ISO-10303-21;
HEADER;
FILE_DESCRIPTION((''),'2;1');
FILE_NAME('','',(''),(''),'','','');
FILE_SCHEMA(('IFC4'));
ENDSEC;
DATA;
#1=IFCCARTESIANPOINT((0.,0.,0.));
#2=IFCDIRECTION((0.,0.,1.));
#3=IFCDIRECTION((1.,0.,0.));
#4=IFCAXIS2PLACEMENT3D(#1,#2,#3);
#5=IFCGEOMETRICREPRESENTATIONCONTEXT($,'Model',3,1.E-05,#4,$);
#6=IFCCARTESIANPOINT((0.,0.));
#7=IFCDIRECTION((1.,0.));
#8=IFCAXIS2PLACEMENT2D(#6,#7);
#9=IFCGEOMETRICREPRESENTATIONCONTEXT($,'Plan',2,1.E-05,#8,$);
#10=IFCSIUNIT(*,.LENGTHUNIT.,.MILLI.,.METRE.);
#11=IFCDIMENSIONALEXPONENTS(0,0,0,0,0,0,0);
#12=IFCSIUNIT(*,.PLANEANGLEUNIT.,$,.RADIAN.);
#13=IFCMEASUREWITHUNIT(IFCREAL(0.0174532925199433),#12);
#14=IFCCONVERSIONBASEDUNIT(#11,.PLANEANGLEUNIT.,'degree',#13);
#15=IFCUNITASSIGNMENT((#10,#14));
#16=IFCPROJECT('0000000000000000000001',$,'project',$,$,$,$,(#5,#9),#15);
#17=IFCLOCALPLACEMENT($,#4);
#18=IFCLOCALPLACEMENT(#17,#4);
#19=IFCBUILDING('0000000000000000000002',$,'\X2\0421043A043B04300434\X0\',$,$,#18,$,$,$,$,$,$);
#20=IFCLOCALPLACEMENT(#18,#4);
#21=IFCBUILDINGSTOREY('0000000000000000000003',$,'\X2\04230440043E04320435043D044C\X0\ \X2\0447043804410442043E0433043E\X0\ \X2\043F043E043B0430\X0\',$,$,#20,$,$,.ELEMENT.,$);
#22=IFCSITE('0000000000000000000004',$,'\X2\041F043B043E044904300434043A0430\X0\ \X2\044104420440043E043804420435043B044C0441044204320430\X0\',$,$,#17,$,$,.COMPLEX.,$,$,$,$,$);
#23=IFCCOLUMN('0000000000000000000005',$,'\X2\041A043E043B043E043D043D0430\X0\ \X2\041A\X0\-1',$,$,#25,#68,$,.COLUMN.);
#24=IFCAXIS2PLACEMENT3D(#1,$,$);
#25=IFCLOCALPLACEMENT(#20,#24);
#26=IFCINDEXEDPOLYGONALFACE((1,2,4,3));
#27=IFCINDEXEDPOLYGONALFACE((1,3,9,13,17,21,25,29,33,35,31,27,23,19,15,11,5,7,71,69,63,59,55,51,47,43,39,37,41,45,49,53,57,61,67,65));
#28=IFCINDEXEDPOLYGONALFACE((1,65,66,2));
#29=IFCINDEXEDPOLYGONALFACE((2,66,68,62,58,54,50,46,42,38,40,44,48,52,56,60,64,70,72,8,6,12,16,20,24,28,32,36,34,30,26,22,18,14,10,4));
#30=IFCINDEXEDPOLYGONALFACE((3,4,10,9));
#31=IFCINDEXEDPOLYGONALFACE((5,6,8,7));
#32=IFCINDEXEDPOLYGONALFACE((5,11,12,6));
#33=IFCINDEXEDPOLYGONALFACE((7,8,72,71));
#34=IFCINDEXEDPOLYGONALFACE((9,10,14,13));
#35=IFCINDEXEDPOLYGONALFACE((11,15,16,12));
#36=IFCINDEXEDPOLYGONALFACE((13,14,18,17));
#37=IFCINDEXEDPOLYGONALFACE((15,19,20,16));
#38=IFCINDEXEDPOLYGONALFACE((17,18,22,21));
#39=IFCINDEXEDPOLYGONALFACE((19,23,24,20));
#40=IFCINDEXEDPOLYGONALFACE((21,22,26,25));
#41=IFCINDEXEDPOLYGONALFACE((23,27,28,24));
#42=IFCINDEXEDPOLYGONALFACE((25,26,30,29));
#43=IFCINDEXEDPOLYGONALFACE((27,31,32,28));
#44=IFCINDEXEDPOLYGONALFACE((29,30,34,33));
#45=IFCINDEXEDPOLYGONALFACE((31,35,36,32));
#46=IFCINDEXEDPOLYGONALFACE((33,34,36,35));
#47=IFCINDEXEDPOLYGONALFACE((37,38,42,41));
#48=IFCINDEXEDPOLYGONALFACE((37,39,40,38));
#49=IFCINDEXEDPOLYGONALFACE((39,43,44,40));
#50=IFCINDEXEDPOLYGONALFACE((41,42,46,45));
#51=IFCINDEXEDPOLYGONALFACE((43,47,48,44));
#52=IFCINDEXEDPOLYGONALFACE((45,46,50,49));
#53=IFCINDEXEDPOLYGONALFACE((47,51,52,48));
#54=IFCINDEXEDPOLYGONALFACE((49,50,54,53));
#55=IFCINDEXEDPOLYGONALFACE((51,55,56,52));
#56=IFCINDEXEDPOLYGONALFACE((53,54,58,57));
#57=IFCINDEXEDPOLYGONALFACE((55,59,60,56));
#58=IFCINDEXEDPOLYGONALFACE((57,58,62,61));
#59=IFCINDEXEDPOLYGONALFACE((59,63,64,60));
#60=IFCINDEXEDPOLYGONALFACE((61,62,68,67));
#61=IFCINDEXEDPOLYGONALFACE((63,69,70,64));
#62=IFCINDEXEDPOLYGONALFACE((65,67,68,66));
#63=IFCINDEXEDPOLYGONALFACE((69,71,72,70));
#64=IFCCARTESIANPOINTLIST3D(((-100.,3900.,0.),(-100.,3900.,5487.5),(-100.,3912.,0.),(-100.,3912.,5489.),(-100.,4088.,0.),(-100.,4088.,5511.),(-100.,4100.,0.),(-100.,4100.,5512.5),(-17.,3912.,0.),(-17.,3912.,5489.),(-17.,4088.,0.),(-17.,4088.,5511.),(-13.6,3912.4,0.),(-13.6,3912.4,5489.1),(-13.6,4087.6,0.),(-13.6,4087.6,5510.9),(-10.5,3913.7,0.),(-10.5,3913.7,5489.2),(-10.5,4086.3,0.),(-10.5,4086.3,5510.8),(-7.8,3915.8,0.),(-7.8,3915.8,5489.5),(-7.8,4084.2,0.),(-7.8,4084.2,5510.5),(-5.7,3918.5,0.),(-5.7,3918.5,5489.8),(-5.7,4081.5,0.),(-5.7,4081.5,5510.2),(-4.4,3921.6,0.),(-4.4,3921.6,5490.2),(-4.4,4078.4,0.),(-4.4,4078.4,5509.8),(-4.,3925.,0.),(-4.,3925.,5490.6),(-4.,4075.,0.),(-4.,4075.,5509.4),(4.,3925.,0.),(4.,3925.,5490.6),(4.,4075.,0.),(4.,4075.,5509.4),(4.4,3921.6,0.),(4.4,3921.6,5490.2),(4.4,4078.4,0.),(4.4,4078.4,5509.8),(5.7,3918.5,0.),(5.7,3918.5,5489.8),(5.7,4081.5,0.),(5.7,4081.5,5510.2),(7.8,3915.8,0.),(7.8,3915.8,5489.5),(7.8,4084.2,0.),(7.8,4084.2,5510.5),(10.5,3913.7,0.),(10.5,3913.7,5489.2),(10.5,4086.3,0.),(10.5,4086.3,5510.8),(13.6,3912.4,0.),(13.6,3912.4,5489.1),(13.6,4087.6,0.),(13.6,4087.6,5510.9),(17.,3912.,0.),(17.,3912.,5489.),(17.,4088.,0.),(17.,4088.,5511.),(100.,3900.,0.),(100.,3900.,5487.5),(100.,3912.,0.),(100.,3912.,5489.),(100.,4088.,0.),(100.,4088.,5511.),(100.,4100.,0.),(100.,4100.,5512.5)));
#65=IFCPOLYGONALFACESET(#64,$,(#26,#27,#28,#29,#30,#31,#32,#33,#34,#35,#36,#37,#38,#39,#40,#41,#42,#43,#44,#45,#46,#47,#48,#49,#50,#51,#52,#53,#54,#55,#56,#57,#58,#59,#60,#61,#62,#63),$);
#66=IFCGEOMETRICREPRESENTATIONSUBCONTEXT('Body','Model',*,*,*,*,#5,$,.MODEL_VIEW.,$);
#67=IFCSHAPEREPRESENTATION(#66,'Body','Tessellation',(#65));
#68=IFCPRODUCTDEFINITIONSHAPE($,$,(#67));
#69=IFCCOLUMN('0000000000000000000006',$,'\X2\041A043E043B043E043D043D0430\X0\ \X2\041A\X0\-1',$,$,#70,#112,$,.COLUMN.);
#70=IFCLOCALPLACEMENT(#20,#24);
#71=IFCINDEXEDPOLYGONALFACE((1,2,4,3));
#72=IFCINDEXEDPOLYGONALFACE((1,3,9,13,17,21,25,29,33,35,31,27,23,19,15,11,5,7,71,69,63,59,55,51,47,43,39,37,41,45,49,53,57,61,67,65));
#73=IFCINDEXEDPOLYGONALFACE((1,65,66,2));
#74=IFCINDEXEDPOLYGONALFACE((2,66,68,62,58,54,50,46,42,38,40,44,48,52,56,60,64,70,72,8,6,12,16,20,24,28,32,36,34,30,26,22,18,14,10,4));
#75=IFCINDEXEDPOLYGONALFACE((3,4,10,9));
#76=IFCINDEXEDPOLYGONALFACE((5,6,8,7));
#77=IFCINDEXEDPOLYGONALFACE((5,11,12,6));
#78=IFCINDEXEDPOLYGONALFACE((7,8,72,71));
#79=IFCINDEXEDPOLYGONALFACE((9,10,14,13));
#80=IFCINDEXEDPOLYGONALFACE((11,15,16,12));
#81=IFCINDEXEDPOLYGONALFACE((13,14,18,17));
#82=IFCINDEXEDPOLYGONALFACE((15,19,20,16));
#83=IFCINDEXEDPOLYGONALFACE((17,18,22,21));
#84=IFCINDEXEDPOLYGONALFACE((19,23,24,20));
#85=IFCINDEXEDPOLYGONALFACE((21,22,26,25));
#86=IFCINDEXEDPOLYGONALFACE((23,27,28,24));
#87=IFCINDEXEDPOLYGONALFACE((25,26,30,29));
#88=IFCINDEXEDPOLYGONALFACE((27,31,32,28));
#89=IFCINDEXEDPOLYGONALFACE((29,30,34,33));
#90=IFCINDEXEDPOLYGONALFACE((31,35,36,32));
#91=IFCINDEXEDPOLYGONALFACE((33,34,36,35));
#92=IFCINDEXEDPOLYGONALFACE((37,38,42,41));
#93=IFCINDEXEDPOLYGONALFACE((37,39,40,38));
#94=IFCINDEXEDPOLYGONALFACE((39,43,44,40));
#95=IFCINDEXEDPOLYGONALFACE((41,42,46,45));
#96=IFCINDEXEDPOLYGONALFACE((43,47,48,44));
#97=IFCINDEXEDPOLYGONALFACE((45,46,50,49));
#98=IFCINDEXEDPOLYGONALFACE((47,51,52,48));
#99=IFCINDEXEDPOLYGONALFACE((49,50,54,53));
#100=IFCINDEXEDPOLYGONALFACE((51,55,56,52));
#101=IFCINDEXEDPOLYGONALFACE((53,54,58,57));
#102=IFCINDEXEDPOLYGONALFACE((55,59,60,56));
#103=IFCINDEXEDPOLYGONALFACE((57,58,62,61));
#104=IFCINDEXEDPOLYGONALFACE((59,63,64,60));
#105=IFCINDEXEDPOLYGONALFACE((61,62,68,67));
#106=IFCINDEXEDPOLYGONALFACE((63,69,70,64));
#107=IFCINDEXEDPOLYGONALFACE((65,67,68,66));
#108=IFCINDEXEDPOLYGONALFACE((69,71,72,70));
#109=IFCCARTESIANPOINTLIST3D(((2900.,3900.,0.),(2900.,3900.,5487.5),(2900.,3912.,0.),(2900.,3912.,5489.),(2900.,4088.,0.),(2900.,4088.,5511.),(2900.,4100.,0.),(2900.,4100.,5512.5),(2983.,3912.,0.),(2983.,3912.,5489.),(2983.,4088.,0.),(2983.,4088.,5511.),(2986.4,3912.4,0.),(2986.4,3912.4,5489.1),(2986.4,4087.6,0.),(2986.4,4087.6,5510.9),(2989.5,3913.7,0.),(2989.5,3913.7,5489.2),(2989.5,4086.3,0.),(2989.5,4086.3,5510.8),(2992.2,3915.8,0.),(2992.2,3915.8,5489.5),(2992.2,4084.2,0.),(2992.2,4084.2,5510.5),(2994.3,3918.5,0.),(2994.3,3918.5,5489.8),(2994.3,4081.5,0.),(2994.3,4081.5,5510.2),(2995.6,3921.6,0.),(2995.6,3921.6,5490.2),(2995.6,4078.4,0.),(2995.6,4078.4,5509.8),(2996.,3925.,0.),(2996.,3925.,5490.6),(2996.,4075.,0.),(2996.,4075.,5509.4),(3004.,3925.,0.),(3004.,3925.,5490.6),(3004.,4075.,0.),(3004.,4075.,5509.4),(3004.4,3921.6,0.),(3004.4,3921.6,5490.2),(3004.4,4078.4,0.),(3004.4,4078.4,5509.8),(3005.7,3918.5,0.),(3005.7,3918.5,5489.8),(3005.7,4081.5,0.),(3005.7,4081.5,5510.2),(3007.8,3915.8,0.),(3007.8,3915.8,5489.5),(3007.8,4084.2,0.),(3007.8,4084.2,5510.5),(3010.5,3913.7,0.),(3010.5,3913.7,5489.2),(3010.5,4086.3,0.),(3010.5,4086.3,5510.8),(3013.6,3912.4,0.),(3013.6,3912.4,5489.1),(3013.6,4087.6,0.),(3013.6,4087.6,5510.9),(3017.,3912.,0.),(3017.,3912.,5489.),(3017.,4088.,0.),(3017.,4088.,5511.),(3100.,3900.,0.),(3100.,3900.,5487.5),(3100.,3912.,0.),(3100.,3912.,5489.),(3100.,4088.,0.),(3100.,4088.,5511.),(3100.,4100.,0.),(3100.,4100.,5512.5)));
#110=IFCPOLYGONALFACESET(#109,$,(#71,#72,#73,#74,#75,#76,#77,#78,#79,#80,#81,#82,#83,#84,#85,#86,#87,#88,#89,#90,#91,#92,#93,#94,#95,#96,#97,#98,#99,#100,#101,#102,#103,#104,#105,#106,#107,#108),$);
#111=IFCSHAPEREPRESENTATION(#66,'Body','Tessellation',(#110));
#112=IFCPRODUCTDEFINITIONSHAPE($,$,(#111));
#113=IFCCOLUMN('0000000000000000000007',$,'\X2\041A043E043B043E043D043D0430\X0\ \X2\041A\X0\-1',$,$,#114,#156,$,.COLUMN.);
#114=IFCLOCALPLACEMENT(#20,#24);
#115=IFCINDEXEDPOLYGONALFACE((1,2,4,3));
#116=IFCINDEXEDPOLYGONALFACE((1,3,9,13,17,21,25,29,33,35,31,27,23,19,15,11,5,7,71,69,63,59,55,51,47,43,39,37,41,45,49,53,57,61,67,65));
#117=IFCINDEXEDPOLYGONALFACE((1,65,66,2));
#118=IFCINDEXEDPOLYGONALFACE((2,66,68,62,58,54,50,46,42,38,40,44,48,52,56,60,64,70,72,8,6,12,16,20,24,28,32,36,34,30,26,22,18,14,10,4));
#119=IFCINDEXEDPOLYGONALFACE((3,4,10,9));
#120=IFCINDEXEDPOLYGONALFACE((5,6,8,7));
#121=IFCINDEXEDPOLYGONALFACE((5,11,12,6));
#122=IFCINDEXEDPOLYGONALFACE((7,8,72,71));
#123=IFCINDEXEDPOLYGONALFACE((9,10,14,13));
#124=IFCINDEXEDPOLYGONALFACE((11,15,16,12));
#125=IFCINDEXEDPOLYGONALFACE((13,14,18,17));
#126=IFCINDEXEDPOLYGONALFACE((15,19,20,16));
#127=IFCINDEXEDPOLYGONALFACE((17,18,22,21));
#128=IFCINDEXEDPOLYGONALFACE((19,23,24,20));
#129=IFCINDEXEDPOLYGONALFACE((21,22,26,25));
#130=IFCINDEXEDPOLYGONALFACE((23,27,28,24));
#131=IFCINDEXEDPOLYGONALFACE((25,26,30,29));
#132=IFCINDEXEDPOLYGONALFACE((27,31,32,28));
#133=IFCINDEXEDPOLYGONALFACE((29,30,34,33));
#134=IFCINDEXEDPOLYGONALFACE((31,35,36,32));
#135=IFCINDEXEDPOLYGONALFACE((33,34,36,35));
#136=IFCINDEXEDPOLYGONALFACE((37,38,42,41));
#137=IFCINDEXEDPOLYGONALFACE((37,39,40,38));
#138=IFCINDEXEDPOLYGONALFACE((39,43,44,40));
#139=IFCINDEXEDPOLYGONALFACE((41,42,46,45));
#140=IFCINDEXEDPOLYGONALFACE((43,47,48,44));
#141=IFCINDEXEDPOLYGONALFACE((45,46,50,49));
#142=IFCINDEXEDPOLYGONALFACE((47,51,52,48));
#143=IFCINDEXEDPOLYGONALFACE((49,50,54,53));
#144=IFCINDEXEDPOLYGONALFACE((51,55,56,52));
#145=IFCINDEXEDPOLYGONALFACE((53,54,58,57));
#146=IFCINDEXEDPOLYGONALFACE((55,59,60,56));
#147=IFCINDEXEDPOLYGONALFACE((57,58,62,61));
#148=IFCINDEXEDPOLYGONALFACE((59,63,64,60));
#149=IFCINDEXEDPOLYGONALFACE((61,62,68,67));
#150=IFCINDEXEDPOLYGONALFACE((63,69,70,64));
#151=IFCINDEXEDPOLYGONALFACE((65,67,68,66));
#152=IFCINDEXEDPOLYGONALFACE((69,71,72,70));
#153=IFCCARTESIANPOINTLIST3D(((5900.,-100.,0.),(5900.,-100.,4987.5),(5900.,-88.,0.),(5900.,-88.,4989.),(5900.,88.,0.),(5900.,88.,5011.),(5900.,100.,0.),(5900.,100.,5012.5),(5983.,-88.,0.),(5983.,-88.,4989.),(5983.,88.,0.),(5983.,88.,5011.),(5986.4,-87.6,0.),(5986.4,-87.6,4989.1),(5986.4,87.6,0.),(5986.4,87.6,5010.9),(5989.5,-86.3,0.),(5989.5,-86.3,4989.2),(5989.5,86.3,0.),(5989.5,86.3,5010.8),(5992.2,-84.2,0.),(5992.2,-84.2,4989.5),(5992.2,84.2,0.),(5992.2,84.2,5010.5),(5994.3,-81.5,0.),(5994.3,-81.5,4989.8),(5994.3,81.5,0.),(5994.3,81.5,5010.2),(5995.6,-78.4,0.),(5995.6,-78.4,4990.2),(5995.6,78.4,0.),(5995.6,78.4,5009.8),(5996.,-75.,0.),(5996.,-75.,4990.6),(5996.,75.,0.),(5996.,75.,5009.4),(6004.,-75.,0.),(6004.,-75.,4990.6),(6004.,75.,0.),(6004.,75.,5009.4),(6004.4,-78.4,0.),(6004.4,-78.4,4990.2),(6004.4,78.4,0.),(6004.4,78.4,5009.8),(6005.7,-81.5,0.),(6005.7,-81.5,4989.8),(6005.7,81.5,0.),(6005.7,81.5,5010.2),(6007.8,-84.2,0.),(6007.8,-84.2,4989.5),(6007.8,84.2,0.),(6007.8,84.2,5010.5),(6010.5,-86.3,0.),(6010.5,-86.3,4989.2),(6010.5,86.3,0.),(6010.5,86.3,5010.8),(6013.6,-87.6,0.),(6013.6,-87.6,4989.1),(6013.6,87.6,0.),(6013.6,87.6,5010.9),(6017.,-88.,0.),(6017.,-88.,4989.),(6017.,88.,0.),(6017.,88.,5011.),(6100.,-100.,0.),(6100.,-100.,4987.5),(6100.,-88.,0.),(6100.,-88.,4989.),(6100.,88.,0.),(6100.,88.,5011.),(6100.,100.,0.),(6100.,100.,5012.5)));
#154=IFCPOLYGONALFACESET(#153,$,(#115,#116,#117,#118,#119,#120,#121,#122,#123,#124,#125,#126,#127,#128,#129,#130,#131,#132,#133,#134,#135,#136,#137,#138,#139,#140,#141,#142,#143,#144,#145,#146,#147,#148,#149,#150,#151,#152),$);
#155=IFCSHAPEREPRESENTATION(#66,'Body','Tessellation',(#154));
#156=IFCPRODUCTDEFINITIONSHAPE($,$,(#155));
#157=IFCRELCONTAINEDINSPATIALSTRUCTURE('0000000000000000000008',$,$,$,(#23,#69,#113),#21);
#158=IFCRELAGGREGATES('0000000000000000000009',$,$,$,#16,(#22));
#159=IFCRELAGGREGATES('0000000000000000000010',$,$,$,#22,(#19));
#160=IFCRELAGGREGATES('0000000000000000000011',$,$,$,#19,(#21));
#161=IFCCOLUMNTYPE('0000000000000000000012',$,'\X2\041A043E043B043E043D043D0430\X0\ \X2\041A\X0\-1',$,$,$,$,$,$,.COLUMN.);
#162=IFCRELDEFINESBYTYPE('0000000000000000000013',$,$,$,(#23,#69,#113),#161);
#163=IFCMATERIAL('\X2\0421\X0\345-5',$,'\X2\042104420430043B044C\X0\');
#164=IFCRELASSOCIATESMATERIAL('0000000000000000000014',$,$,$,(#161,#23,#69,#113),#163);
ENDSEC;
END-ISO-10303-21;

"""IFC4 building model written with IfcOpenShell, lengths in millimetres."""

from ifc_helpers import new_model, entity, si_unit, converted_unit, frame, origin_with_axes, origin_2d_with_axis, place, context, subcontext, project, spatial, i_section, extrude, clip, halfspace, material, material_profile, profile_set, profile_usage, type_object, element, save


model = new_model("IFC4")

# Units and contexts
model_context = context("Model", 3, precision=1e-05, world=origin_with_axes())
plan_context = context("Plan", 2, precision=1e-05, world=origin_2d_with_axis())
body_context = subcontext(model_context, "Body", "Model", "MODEL_VIEW")
ifc_project = project(units=[si_unit("LENGTHUNIT", "METRE", prefix="MILLI"), converted_unit("PLANEANGLEUNIT", "degree", entity("IfcReal", 0.0174532925199433), si_unit("PLANEANGLEUNIT", "RADIAN"), dimensions=[0, 0, 0, 0, 0, 0, 0])], contexts=[model_context, plan_context])

# Site, building, storey
site_placement = place(None, origin_with_axes())
site = spatial("IfcSite", under=ifc_project, at=site_placement, Name="Площадка строительства", CompositionType="COMPLEX")
building_placement = place(site_placement, origin_with_axes())
building = spatial("IfcBuilding", under=site, at=building_placement, Name="Склад")
storey_placement = place(building_placement, origin_with_axes())
storey = spatial("IfcBuildingStorey", under=building, at=storey_placement, Name="Уровень чистого пола", CompositionType="ELEMENT")

# Columns
ifc_material_1 = material(Name="С345-5", Category="Сталь")
ifc_material_profile_1 = material_profile(ifc_material_1, i_section(OverallWidth=200.0, OverallDepth=200.0, WebThickness=8.0, FlangeThickness=12.0, FilletRadius=13.0, FlangeEdgeRadius=0.0, FlangeSlope=0.0))
ifc_profile_set_1 = profile_set([ifc_material_profile_1], Name="I20K2_S345-5")
ifc_profile_usage_1 = profile_usage(ifc_profile_set_1, cardinal=5)
column_type = type_object("IfcColumnType", Name="Колонна К-1", PredefinedType="COLUMN", material=ifc_profile_set_1)
column_1_placement = place(storey_placement, frame((0.0, 4000.0, 0.0), z_axis=(0.0, 0.0, 1.0), x_axis=(1.0, 0.0, 0.0)))
element("IfcColumn", 1, at=column_1_placement, inside=storey, type_object=column_type, material=ifc_profile_usage_1, Name="Колонна К-1", PredefinedType="COLUMN", context=body_context, shape_type="Clipping", body=[
    clip(extrude(i_section(OverallWidth=200.0, OverallDepth=200.0, WebThickness=8.0, FlangeThickness=12.0, FilletRadius=13.0, FlangeEdgeRadius=0.0, FlangeSlope=0.0), origin_with_axes(), (0.0, 0.0, 1.0), 5700.0), halfspace(frame((0.0, -4298.5, 4962.7), z_axis=(0.0, -0.124035, 0.992278), x_axis=(0.0, 0.992278, 0.124035)), False)),
])
ifc_profile_usage_2 = profile_usage(ifc_profile_set_1, cardinal=5)
column_2_placement = place(storey_placement, frame((3000.0, 4000.0, 0.0), z_axis=(0.0, 0.0, 1.0), x_axis=(1.0, 0.0, 0.0)))
element("IfcColumn", 2, at=column_2_placement, inside=storey, type_object=column_type, material=ifc_profile_usage_2, Name="Колонна К-1", PredefinedType="COLUMN", context=body_context, shape_type="Clipping", body=[
    clip(extrude(i_section(OverallWidth=200.0, OverallDepth=200.0, WebThickness=8.0, FlangeThickness=12.0, FilletRadius=13.0, FlangeEdgeRadius=0.0, FlangeSlope=0.0), origin_with_axes(), (0.0, 0.0, 1.0), 5700.0), halfspace(frame((0.0, -4298.5, 4962.7), z_axis=(0.0, -0.124035, 0.992278), x_axis=(0.0, 0.992278, 0.124035)), False)),
])
ifc_profile_usage_3 = profile_usage(ifc_profile_set_1, cardinal=5)
column_3_placement = place(storey_placement, frame((6000.0, 0.0, 0.0), z_axis=(0.0, 0.0, 1.0), x_axis=(1.0, 0.0, 0.0)))
element("IfcColumn", 3, at=column_3_placement, inside=storey, type_object=column_type, material=ifc_profile_usage_3, Name="Колонна К-1", PredefinedType="COLUMN", context=body_context, shape_type="Clipping", body=[
    clip(extrude(i_section(OverallWidth=200.0, OverallDepth=200.0, WebThickness=8.0, FlangeThickness=12.0, FilletRadius=13.0, FlangeEdgeRadius=0.0, FlangeSlope=0.0), origin_with_axes(), (0.0, 0.0, 1.0), 5200.0), halfspace(frame((0.0, -298.5, 4962.7), z_axis=(0.0, -0.124035, 0.992278), x_axis=(0.0, 0.992278, 0.124035)), False)),
])

save(model, "model.ifc")
